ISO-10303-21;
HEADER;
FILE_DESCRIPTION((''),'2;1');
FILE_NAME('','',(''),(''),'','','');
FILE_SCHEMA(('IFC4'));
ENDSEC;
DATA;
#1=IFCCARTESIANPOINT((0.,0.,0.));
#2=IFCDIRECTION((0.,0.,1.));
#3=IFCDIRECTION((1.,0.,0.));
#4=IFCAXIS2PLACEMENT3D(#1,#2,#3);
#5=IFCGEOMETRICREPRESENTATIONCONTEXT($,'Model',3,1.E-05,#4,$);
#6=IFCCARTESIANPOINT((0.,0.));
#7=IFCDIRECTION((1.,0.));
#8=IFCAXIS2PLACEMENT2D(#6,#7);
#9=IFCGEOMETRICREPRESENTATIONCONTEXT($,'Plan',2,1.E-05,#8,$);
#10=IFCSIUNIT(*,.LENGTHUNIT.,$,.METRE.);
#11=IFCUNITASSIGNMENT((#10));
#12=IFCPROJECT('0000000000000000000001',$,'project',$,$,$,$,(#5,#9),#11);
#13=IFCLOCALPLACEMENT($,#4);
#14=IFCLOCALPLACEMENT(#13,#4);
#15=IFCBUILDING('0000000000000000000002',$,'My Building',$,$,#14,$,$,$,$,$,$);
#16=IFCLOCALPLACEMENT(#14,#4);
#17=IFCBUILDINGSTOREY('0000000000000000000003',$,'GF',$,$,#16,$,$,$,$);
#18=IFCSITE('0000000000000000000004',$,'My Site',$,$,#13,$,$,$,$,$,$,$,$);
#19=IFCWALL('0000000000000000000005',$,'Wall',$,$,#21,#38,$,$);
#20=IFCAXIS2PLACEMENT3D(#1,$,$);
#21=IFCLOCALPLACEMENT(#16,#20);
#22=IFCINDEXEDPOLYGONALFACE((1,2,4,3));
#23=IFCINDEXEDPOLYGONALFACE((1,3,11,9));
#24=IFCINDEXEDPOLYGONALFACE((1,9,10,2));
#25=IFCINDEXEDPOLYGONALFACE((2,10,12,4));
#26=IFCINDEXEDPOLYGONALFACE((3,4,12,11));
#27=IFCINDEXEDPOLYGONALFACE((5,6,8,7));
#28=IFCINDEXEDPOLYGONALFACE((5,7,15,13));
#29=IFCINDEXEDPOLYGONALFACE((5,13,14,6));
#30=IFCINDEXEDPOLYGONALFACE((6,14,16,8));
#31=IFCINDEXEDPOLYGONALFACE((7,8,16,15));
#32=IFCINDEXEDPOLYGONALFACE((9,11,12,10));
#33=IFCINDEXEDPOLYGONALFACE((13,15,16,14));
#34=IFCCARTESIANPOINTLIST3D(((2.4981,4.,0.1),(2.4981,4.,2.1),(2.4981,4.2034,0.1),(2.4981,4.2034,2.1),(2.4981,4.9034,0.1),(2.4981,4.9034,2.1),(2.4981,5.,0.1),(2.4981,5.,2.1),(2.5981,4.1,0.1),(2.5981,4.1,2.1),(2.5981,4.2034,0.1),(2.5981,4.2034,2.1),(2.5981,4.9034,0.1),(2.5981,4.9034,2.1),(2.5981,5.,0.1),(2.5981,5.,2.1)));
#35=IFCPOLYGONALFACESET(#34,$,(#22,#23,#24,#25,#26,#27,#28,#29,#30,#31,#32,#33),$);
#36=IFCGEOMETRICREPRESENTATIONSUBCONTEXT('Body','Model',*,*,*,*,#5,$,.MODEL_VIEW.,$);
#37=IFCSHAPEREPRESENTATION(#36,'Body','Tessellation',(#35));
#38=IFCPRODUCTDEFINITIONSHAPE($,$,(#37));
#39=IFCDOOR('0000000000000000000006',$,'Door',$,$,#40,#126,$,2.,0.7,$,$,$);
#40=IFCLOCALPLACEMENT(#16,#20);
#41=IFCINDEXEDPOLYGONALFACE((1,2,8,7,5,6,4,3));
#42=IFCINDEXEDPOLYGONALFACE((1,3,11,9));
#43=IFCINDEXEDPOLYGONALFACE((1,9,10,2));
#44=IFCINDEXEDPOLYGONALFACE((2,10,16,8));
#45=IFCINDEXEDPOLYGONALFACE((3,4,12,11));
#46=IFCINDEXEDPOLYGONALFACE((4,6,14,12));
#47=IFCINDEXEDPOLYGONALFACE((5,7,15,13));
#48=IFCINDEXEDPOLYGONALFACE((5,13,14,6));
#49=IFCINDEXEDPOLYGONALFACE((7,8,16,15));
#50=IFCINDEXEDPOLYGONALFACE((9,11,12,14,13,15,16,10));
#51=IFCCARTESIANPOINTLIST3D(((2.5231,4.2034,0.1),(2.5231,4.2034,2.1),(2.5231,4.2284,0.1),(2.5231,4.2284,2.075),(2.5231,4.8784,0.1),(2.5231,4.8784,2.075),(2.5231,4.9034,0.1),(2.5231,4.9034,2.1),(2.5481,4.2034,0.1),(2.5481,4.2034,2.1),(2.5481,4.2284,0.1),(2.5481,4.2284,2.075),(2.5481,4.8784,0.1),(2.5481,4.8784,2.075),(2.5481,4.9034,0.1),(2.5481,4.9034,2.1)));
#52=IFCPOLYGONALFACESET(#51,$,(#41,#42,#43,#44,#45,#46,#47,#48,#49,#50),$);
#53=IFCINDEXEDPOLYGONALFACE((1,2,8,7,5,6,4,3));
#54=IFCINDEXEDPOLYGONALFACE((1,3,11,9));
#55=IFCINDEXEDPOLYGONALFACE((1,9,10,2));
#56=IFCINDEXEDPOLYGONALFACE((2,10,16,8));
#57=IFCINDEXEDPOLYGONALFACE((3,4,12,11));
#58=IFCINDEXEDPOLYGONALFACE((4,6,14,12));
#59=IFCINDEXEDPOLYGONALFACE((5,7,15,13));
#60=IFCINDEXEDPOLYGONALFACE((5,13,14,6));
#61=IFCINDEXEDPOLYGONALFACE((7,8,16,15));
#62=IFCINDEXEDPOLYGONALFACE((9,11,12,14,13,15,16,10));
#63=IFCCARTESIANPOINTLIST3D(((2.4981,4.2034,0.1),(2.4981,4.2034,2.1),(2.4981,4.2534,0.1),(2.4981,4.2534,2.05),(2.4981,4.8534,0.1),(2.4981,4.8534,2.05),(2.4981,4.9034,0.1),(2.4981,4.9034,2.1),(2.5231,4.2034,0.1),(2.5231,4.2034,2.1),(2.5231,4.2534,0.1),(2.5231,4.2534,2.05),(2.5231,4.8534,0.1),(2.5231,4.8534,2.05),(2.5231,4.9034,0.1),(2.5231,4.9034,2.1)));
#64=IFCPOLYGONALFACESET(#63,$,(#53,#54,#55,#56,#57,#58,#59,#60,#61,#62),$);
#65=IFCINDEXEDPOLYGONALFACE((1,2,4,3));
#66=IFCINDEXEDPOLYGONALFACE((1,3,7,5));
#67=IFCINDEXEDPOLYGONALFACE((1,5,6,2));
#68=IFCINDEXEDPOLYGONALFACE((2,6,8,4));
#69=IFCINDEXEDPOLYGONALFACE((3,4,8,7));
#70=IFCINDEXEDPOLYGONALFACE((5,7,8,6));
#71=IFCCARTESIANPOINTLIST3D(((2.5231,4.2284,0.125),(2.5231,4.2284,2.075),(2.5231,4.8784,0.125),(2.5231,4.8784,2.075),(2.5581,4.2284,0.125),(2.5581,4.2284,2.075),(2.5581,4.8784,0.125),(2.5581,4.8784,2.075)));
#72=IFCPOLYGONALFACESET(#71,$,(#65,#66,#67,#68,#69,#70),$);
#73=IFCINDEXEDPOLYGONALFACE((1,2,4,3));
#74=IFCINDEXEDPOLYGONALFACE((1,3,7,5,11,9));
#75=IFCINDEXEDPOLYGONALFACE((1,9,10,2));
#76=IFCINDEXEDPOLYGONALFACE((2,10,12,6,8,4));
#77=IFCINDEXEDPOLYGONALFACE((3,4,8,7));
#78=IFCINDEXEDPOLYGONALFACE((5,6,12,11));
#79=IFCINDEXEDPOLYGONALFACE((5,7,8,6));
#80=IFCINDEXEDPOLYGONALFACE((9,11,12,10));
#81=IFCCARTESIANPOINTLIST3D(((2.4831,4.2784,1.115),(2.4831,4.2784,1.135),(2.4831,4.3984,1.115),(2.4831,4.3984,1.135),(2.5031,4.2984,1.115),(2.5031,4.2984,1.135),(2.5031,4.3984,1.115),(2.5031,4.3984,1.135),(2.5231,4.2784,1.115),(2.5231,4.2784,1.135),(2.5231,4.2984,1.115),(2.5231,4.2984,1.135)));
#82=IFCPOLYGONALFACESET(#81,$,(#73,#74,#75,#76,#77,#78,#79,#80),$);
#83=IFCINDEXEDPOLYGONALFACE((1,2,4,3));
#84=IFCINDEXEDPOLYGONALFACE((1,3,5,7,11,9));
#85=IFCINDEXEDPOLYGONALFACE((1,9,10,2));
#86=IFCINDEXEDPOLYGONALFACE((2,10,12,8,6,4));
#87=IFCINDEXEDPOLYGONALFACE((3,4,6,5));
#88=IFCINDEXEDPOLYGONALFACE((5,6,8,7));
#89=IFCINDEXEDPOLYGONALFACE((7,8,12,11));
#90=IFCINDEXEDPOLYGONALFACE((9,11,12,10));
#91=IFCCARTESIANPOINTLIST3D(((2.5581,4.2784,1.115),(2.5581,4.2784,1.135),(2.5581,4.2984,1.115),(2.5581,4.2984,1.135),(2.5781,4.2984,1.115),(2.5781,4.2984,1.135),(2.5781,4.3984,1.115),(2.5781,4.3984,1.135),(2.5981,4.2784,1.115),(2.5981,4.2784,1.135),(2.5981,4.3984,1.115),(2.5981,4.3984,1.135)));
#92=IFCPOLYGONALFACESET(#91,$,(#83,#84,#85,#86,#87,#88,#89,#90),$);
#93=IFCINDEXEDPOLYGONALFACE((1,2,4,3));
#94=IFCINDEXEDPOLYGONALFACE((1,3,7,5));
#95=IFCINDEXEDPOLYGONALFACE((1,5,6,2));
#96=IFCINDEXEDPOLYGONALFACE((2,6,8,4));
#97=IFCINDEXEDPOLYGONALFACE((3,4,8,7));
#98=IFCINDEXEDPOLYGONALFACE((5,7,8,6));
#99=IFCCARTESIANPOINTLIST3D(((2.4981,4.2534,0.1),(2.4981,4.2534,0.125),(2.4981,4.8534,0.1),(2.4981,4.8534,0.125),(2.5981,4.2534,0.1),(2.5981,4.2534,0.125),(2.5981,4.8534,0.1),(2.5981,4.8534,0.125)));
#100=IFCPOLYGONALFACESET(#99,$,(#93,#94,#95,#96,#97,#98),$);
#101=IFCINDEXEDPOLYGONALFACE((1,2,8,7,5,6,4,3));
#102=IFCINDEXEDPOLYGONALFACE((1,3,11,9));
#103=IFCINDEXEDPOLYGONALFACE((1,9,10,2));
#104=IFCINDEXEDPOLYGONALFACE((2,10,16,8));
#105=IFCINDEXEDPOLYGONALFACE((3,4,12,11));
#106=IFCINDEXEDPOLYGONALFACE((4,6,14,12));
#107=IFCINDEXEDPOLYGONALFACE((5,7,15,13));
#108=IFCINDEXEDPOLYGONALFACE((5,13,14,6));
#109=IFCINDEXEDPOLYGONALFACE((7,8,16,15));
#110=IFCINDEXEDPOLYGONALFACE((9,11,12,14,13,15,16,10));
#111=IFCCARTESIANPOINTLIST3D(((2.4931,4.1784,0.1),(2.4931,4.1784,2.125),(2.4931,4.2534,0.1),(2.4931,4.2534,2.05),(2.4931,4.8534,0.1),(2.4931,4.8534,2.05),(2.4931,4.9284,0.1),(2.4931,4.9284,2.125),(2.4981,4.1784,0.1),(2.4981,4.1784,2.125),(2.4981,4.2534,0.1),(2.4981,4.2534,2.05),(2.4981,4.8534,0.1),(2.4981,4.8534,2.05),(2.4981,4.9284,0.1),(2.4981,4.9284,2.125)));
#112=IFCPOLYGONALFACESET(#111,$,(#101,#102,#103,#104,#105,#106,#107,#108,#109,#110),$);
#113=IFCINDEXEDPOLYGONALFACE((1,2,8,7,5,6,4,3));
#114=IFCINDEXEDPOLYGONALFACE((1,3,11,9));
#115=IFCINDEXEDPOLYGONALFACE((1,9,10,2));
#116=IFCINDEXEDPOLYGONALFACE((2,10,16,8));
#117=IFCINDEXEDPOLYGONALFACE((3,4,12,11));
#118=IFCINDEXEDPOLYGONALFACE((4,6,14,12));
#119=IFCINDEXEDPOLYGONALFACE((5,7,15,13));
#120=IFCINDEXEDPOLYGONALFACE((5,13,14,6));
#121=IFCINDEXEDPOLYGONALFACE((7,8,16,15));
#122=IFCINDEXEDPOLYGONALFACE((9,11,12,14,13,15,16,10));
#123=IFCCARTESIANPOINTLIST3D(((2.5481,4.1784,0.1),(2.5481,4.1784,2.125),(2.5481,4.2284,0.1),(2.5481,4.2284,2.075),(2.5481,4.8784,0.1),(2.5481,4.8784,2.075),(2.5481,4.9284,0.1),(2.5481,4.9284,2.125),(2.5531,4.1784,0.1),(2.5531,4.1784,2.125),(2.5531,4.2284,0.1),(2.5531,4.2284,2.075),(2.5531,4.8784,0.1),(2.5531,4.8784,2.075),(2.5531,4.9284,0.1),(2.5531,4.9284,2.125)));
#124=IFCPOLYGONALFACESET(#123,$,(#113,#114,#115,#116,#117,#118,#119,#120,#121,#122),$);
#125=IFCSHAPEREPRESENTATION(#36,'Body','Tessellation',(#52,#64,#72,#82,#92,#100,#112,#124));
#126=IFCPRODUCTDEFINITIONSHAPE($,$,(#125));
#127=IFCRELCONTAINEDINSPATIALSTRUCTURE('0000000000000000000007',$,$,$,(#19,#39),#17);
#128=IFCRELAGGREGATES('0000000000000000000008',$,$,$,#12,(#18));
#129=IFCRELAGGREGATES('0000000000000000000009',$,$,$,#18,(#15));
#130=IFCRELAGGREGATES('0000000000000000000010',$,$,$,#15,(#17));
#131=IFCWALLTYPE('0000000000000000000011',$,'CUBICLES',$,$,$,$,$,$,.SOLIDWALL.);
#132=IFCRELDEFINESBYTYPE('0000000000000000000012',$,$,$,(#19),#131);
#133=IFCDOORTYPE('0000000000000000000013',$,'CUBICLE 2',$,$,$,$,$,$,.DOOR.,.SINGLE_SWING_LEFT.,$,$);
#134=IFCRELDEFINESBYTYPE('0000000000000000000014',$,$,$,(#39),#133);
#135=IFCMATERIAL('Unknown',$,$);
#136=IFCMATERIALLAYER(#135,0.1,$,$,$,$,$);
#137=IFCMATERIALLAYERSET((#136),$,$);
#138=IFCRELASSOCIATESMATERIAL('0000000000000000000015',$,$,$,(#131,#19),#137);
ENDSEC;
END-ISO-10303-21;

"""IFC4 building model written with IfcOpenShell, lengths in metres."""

from ifc_helpers import new_model, entity, si_unit, frame, origin_with_axes, origin_2d_with_axis, place, context, subcontext, project, spatial, line, indexed_curve, outline, extrude, shape, source, transform, mapped, material, layer, layer_set, layer_usage, type_object, type_shapes, element, fill, save


model = new_model("IFC4")

# Units and contexts
model_context = context("Model", 3, precision=1e-05, world=origin_with_axes())
plan_context = context("Plan", 2, precision=1e-05, world=origin_2d_with_axis())
body_context_1 = subcontext(model_context, "Body", "Model", "MODEL_VIEW")
body_context_2 = subcontext(plan_context, "Body", "Plan", "PLAN_VIEW")
ifc_project = project(units=[si_unit("LENGTHUNIT", "METRE")], contexts=[model_context, plan_context])

# Site, building, storey
site_placement = place(None, origin_with_axes())
site = spatial("IfcSite", under=ifc_project, at=site_placement, Name="My Site")
building_placement = place(site_placement, origin_with_axes())
building = spatial("IfcBuilding", under=site, at=building_placement, Name="My Building")
storey_placement = place(building_placement, origin_with_axes())
storey = spatial("IfcBuildingStorey", under=building, at=storey_placement, Name="GF")

# Shared definitions
ifc_material = material(Name="Unknown")

# Wall, opening, door
ifc_layer_1 = layer(ifc_material, 0.1)
ifc_layer_set_1 = layer_set([ifc_layer_1])
ifc_layer_usage_1 = layer_usage(ifc_layer_set_1, "AXIS2", "POSITIVE", 0.0)
wall_type_1 = type_object("IfcWallType", Name="CUBICLES", PredefinedType="SOLIDWALL", material=ifc_layer_set_1)
wall_1_placement = place(storey_placement, frame((2.5981, 4.0, 0.1), z_axis=(0.0, 0.0, 1.0), x_axis=(0.0, 1.0, 0.0)))
wall_1 = element("IfcWall", 1, at=wall_1_placement, inside=storey, type_object=wall_type_1, material=ifc_layer_usage_1, Name="Wall", context=body_context_1, shape_type="SweptSolid", body=[
    extrude(outline(indexed_curve([(0.1, 0.0), (0.0, 0.1), (1.0, 0.1), (1.0, 0.0)], segments=[line(1, 2, 3, 4, 1)])), origin_with_axes(), (0.0, 0.0, 1.0), 2.0),
])
shared_shape_1 = source(origin_with_axes(), body_context_1, "Body", "SweptSolid", [
    extrude(outline(indexed_curve([(0.0, 0.0), (0.7, 0.0), (0.7, 2.0), (0.0, 2.0)], segments=[line(1, 2, 3, 4, 1)])), frame((0.0, -0.6, 0.0), z_axis=(0.0, -1.0, 0.0), x_axis=(1.0, 0.0, 0.0)), (0.0, 0.0, -1.0), 1.2),
])
opening_1_placement = place(wall_1_placement, frame((0.9034, 0.1, 0.0), z_axis=(0.0, 0.0, 1.0), x_axis=(-1.0, 0.0, 0.0)))
opening_1 = element("IfcOpeningElement", 2, at=opening_1_placement, cuts=wall_1, PredefinedType="OPENING", context=body_context_1, shape_type="MappedRepresentation", body=[
    mapped(shared_shape_1, transform((0.0, 0.0, 0.0), x_axis=(1.0, 0.0, 0.0), y_axis=(0.0, 1.0, 0.0), z_axis=(0.0, 0.0, 1.0), scale=1.0)),
])
door_type_1 = type_object("IfcDoorType", Name="CUBICLE 2", OperationType="SINGLE_SWING_LEFT", PredefinedType="DOOR")
shared_shape_2 = source(origin_with_axes(), body_context_1, "Body", "SweptSolid", [
    extrude(outline(indexed_curve([(0.0, 0.0), (0.0, 2.0), (0.7, 2.0), (0.7, 0.0), (0.675, 0.0), (0.675, 1.975), (0.025, 1.975), (0.025, 0.0)], segments=[line(1, 2, 3, 4, 5, 6, 7, 8, 1)])), frame((0.0, 0.025, 0.0), z_axis=(0.0, -1.0, 0.0), x_axis=(1.0, 0.0, 0.0)), (0.0, 0.0, -1.0), 0.025),
    extrude(outline(indexed_curve([(0.0, 0.0), (0.0, 2.0), (0.7, 2.0), (0.7, 0.0), (0.65, 0.0), (0.65, 1.95), (0.05, 1.95), (0.05, 0.0)], segments=[line(1, 2, 3, 4, 5, 6, 7, 8, 1)])), frame((0.0, 0.0, 0.0), z_axis=(0.0, -1.0, 0.0), x_axis=(1.0, 0.0, 0.0)), (0.0, 0.0, -1.0), 0.025),
    extrude(outline(indexed_curve([(0.0, 0.0), (0.65, 0.0), (0.65, 0.035), (0.0, 0.035)], segments=[line(1, 2, 3, 4, 1)])), frame((0.025, 0.025, 0.025), z_axis=(0.0, 0.0, 1.0), x_axis=(1.0, 0.0, 0.0)), (0.0, 0.0, 1.0), 1.95),
    extrude(outline(indexed_curve([(0.0, 0.0), (0.0, -0.04), (-0.12, -0.04), (-0.12, -0.02), (-0.02, -0.02), (-0.02, 0.0)], segments=[line(1, 2, 3, 4, 5, 6, 1)])), frame((0.625, 0.025, 1.015), z_axis=(0.0, 0.0, 1.0), x_axis=(1.0, 0.0, 0.0)), (0.0, 0.0, 1.0), 0.02),
    extrude(outline(indexed_curve([(0.0, 0.0), (0.0, 0.04), (-0.12, 0.04), (-0.12, 0.02), (-0.02, 0.02), (-0.02, 0.0)], segments=[line(1, 2, 3, 4, 5, 6, 1)])), frame((0.625, 0.06, 1.015), z_axis=(0.0, 0.0, 1.0), x_axis=(1.0, 0.0, 0.0)), (0.0, 0.0, 1.0), 0.02),
    extrude(outline(indexed_curve([(0.0, 0.0), (0.6, 0.0), (0.6, 0.1), (0.0, 0.1)], segments=[line(1, 2, 3, 4, 1)])), frame((0.05, 0.0, 0.0), z_axis=(0.0, 0.0, 1.0), x_axis=(1.0, 0.0, 0.0)), (0.0, 0.0, 1.0), 0.025),
    extrude(outline(indexed_curve([(0.0, 0.0), (0.0, 2.025), (0.75, 2.025), (0.75, 0.0), (0.675, 0.0), (0.675, 1.95), (0.075, 1.95), (0.075, 0.0)], segments=[line(1, 2, 3, 4, 5, 6, 7, 8, 1)])), frame((-0.025, -0.005, 0.0), z_axis=(0.0, -1.0, 0.0), x_axis=(1.0, 0.0, 0.0)), (0.0, 0.0, -1.0), 0.005),
    extrude(outline(indexed_curve([(0.0, 0.0), (0.0, 2.025), (0.75, 2.025), (0.75, 0.0), (0.7, 0.0), (0.7, 1.975), (0.05, 1.975), (0.05, 0.0)], segments=[line(1, 2, 3, 4, 5, 6, 7, 8, 1)])), frame((-0.025, 0.05, 0.0), z_axis=(0.0, -1.0, 0.0), x_axis=(1.0, 0.0, 0.0)), (0.0, 0.0, -1.0), 0.005),
])
shared_shape_3 = source(origin_with_axes(), body_context_2, "Body", "Curve2D", [
    entity("IfcIndexedPolyCurve", entity("IfcCartesianPointList2D", [[0.0, 0.0], [0.0, 0.05], [0.025, 0.05], [0.025, 0.025], [0.05, 0.025], [0.05, 0.0]]), [entity("IfcLineIndex", [1, 2, 3, 4, 5, 6, 1])]),
    entity("IfcIndexedPolyCurve", entity("IfcCartesianPointList2D", [[0.7, 0.0], [0.7, 0.05], [0.675, 0.05], [0.675, 0.025], [0.65, 0.025], [0.65, 0.0]]), [entity("IfcLineIndex", [1, 2, 3, 4, 5, 6, 1])]),
    entity("IfcTrimmedCurve", entity("IfcEllipse", entity("IfcAxis2Placement2D", entity("IfcCartesianPoint", [0.06, 0.05]), entity("IfcDirection", [1.0, 0.0])), 0.615, 0.65), [entity("IfcCartesianPoint", [0.675, 0.05])], [entity("IfcCartesianPoint", [0.06, 0.7])], True, "CARTESIAN"),
    entity("IfcIndexedPolyCurve", entity("IfcCartesianPointList2D", [[0.025, 0.05], [0.06, 0.05], [0.06, 0.7], [0.025, 0.7]]), [entity("IfcLineIndex", [1, 2, 3, 4, 1])]),
])
type_shapes(door_type_1, [shared_shape_2, shared_shape_3])
door_1_placement = place(opening_1_placement, frame((0.0, 0.0, 0.0), z_axis=(0.0, 0.0, 1.0), x_axis=(1.0, 0.0, 0.0)))
door_1 = element("IfcDoor", 3, at=door_1_placement, inside=storey, type_object=door_type_1, Name="Door", OverallHeight=2.0, OverallWidth=0.7, shapes=[
    shape(body_context_1, "Body", "MappedRepresentation", [mapped(shared_shape_2, transform((0.0, 0.0, 0.0), x_axis=(1.0, 0.0, 0.0), y_axis=(0.0, 1.0, 0.0), z_axis=(0.0, 0.0, 1.0), scale=1.0))]),
    shape(body_context_2, "Body", "MappedRepresentation", [mapped(shared_shape_3, transform((0.0, 0.0, 0.0), x_axis=(1.0, 0.0, 0.0), y_axis=(0.0, 1.0, 0.0), z_axis=(0.0, 0.0, 1.0), scale=1.0))]),
])
fill(opening_1, door_1)

save(model, "model.ifc")
